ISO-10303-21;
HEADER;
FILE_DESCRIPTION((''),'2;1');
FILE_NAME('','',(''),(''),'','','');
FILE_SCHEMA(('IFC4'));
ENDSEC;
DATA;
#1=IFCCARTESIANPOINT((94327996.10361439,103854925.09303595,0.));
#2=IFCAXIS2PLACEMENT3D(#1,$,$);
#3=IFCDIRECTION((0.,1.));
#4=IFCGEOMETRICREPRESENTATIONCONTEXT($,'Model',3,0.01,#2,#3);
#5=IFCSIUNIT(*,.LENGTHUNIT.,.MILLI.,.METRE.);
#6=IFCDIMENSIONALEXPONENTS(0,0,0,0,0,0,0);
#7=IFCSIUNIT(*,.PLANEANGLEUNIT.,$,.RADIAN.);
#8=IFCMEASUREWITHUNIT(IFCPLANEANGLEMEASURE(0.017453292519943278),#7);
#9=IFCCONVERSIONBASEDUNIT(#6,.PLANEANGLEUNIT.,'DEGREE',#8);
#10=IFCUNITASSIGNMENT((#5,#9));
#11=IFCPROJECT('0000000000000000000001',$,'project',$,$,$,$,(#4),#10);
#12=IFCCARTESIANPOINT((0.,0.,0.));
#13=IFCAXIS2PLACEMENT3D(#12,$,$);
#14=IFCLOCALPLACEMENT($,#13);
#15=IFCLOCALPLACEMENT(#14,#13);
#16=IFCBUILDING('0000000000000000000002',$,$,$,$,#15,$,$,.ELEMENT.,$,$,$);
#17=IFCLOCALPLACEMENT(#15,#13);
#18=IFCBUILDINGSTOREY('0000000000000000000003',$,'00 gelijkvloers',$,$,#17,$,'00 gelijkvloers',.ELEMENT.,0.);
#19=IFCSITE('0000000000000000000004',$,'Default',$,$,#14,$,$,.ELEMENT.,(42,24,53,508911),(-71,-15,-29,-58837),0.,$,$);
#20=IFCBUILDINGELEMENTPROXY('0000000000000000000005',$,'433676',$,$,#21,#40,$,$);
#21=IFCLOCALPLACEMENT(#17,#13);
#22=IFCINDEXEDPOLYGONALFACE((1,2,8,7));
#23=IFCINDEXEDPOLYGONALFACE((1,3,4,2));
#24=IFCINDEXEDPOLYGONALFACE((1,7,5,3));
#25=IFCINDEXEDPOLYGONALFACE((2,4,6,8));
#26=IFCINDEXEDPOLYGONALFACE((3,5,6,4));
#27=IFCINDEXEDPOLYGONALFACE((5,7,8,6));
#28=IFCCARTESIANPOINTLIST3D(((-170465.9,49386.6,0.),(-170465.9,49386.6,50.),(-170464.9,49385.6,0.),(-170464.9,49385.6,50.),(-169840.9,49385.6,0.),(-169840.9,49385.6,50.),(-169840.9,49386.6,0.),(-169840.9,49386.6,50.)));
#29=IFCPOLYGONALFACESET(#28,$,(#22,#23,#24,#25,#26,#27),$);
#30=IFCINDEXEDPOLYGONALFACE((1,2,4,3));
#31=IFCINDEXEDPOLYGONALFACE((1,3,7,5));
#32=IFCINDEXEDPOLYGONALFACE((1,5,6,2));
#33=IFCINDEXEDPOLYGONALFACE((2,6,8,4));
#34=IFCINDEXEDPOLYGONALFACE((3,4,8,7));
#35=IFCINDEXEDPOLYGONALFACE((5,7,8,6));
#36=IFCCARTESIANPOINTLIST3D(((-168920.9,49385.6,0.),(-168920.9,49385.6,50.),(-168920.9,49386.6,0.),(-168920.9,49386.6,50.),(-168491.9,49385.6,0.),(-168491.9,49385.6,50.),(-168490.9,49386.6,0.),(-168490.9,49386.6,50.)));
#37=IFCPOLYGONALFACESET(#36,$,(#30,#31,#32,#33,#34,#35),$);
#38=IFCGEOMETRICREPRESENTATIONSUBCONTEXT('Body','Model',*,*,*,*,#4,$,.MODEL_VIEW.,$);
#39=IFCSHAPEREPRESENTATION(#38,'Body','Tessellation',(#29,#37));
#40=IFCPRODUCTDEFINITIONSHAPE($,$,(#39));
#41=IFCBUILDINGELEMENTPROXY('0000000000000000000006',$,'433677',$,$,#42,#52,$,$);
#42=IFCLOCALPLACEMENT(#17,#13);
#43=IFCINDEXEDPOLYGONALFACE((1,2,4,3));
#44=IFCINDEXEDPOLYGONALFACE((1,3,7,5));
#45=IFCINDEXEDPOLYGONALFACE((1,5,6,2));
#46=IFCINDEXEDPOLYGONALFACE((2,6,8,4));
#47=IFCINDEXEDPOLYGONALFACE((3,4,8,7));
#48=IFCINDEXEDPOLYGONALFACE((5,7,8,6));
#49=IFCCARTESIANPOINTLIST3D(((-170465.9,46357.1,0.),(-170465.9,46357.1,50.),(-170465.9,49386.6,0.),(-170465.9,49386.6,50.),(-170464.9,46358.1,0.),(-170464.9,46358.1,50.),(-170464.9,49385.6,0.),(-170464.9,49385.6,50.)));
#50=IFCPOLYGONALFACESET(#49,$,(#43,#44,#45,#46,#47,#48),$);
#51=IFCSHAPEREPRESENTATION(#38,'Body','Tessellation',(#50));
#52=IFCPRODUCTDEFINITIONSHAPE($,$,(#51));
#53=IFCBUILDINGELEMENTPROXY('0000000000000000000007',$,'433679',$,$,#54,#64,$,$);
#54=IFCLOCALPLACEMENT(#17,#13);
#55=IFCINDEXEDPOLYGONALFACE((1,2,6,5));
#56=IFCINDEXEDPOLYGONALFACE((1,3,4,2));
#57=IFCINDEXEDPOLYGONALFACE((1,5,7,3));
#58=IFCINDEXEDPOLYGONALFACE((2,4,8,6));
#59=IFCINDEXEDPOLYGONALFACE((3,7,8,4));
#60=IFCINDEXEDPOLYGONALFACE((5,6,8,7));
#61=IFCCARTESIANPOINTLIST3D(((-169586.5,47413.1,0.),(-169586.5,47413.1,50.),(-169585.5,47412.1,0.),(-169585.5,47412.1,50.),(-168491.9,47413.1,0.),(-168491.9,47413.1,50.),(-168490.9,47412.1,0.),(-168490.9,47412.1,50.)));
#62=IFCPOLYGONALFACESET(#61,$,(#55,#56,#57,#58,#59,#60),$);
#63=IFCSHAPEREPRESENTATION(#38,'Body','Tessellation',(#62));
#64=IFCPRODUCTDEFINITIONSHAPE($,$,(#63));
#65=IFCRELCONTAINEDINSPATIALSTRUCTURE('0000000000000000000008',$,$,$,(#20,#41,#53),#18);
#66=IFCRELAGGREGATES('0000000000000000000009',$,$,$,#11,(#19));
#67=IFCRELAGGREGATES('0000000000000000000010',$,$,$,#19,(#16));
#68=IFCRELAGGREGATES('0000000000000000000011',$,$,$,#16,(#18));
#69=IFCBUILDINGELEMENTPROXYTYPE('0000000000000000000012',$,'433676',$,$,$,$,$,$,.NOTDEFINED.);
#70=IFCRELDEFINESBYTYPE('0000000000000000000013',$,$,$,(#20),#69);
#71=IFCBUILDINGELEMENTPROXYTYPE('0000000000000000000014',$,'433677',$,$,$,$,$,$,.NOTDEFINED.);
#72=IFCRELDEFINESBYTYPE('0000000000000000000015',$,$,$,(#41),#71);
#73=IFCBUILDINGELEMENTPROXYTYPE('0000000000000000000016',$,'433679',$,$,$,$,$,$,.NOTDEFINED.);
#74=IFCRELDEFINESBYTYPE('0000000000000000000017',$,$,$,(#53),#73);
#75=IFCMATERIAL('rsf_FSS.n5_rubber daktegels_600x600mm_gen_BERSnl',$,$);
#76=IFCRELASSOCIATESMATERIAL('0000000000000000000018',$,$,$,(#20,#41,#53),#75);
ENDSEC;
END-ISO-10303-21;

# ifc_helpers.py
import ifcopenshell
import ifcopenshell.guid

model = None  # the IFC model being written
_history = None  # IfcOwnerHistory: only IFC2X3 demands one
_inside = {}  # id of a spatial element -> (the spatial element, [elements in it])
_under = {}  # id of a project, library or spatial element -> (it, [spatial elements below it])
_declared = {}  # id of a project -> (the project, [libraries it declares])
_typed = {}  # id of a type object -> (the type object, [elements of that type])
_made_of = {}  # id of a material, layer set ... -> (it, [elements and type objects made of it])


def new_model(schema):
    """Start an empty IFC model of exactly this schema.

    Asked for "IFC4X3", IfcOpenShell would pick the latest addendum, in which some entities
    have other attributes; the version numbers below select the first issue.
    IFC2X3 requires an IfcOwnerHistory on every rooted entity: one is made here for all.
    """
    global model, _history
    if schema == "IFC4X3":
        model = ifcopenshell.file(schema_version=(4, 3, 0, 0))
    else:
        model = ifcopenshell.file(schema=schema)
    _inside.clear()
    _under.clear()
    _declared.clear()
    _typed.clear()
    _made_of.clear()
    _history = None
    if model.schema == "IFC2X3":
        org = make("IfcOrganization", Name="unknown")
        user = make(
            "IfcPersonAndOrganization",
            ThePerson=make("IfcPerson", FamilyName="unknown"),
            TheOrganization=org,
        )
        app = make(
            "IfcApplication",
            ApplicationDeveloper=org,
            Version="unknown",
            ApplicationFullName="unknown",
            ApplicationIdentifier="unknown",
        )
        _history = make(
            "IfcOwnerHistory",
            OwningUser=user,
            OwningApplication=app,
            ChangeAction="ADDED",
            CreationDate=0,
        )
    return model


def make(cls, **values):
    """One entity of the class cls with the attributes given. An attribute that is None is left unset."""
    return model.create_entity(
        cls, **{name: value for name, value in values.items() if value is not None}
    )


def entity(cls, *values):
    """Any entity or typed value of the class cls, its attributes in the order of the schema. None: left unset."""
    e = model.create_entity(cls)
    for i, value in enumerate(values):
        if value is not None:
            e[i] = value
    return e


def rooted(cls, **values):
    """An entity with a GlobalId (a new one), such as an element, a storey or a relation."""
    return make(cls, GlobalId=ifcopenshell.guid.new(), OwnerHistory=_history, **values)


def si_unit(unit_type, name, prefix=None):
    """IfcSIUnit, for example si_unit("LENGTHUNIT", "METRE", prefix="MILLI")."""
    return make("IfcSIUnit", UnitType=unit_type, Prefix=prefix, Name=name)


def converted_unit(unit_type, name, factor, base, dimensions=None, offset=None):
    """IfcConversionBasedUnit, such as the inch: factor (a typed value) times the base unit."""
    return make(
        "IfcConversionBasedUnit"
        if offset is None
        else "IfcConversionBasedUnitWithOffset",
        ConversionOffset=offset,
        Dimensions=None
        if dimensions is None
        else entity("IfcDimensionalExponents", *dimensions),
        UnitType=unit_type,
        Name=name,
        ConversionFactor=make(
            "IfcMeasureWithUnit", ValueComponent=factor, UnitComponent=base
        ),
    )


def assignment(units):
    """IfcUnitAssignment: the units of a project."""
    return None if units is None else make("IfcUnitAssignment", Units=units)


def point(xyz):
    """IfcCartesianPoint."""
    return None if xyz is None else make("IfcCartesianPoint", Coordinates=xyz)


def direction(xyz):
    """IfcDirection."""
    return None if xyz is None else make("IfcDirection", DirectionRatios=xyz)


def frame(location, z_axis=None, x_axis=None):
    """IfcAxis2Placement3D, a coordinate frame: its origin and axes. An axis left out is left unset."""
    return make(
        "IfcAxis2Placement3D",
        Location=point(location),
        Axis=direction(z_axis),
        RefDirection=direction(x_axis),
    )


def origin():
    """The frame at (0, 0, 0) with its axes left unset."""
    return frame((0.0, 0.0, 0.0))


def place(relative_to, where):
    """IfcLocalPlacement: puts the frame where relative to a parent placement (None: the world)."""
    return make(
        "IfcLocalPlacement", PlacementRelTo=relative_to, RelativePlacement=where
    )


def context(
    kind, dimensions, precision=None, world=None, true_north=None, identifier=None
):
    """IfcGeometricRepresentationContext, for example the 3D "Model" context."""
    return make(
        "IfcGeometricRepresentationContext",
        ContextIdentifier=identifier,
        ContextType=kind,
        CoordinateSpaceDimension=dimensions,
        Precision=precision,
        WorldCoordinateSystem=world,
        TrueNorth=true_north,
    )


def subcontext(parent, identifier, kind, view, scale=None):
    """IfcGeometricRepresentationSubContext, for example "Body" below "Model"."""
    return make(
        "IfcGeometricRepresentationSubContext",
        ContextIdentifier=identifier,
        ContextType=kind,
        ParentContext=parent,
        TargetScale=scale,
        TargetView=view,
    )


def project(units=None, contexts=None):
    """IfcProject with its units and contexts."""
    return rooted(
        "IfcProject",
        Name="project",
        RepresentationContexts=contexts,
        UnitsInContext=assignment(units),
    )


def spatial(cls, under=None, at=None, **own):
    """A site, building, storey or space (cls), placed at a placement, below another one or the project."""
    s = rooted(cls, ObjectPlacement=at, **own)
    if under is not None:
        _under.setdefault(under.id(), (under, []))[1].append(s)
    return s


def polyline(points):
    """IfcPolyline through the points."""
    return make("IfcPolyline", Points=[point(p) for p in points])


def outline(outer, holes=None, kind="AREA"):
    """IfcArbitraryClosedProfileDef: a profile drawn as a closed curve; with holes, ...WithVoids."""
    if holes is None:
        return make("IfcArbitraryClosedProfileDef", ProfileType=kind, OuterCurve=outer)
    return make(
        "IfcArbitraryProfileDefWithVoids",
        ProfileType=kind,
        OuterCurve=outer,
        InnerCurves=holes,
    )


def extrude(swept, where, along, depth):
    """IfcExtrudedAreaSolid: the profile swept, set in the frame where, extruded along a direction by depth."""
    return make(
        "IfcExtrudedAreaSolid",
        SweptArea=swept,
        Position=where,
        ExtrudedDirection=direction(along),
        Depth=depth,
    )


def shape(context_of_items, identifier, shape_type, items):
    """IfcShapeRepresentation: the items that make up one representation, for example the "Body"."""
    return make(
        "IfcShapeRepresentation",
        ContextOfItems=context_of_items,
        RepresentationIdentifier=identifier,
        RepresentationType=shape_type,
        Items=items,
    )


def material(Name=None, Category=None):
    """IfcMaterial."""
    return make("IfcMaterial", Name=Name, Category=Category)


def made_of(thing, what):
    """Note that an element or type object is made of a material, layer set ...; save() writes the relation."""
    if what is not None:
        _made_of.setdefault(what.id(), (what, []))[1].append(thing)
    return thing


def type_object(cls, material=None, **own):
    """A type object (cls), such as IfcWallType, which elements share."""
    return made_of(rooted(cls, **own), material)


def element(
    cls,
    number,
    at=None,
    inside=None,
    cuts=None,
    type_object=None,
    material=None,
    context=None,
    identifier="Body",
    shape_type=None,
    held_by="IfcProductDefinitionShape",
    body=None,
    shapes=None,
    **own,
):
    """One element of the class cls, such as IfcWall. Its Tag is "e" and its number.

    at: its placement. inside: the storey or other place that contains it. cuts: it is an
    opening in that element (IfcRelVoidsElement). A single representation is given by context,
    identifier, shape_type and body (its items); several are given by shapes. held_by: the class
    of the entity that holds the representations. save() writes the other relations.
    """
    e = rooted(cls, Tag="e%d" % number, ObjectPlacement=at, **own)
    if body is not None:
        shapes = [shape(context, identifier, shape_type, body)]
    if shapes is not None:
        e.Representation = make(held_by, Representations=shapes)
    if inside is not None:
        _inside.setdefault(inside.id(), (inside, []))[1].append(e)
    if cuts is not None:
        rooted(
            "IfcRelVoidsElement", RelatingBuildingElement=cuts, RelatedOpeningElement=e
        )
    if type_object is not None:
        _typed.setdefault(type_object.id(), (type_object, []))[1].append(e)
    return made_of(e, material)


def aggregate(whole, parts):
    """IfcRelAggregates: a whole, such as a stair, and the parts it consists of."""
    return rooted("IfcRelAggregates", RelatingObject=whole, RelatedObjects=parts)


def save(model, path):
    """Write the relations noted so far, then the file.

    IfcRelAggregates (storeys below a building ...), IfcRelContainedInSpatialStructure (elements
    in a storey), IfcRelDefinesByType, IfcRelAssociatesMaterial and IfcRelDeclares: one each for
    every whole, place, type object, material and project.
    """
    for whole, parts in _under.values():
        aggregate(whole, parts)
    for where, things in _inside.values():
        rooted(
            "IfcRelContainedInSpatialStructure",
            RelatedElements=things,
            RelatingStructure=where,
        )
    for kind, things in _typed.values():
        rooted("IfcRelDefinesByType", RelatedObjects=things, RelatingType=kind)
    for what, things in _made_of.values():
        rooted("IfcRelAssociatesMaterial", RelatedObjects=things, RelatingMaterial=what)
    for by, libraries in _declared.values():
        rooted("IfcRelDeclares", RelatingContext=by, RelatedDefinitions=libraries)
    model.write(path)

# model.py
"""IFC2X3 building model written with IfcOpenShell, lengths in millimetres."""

from ifc_helpers import new_model, entity, si_unit, converted_unit, direction, frame, origin, place, context, subcontext, project, spatial, polyline, outline, extrude, material, type_object, element, save


model = new_model("IFC2X3")

# Units and contexts
model_context = context("Model", 3, precision=0.01, world=frame((94327996.10361439, 103854925.09303595, 0.0)), true_north=direction((0.0, 1.0)))
body_context = subcontext(model_context, "Body", "Model", "MODEL_VIEW")
ifc_project = project(units=[si_unit("LENGTHUNIT", "METRE", prefix="MILLI"), converted_unit("PLANEANGLEUNIT", "DEGREE", entity("IfcPlaneAngleMeasure", 0.017453292519943278), si_unit("PLANEANGLEUNIT", "RADIAN"), dimensions=[0, 0, 0, 0, 0, 0, 0])], contexts=[model_context])

# Site, building, storey
site_placement = place(None, origin())
site = spatial("IfcSite", under=ifc_project, at=site_placement, Name="Default", CompositionType="ELEMENT", RefLatitude=(42, 24, 53, 508911), RefLongitude=(-71, -15, -29, -58837), RefElevation=0.0)
building_placement = place(site_placement, origin())
building = spatial("IfcBuilding", under=site, at=building_placement, CompositionType="ELEMENT")
storey_placement = place(building_placement, origin())
storey = spatial("IfcBuildingStorey", under=building, at=storey_placement, Name="00 gelijkvloers", LongName="00 gelijkvloers", CompositionType="ELEMENT", Elevation=0.0)

# Building element proxies
ifc_material = material(Name="rsf_FSS.n5_rubber daktegels_600x600mm_gen_BERSnl")
building_element_proxy_type_1 = type_object("IfcBuildingElementProxyType", Name="433676", PredefinedType="NOTDEFINED")
proxy_1_placement = place(storey_placement, origin())
element("IfcBuildingElementProxy", 1, at=proxy_1_placement, inside=storey, type_object=building_element_proxy_type_1, material=ifc_material, Name="433676", context=body_context, shape_type="SweptSolid", body=[
    extrude(outline(polyline([(-311.7, -0.5), (312.2, -0.5), (312.2, 0.5), (-312.7, 0.5), (-311.7, -0.5)])), frame((-170153.1, 49386.1, 0.0)), (0.0, 0.0, 1.0), 50.0),
    extrude(outline(polyline([(-214.8, -0.5), (214.3, -0.5), (215.3, 0.5), (-214.8, 0.5), (-214.8, -0.5)])), frame((-168706.1, 49386.1, 0.0)), (0.0, 0.0, 1.0), 50.0),
])
building_element_proxy_type_2 = type_object("IfcBuildingElementProxyType", Name="433677", PredefinedType="NOTDEFINED")
proxy_2_placement = place(storey_placement, origin())
element("IfcBuildingElementProxy", 2, at=proxy_2_placement, inside=storey, type_object=building_element_proxy_type_2, material=ifc_material, Name="433677", context=body_context, shape_type="SweptSolid", body=[
    extrude(outline(polyline([(-1513.8, -0.5), (1513.8, -0.5), (1514.8, 0.5), (-1514.8, 0.5), (-1513.8, -0.5)])), frame((-170465.4, 47871.8, 0.0), z_axis=(0.0, 0.0, 1.0), x_axis=(0.0, 1.0, 0.0)), (0.0, 0.0, 1.0), 50.0),
])
building_element_proxy_type_3 = type_object("IfcBuildingElementProxyType", Name="433679", PredefinedType="NOTDEFINED")
proxy_3_placement = place(storey_placement, origin())
element("IfcBuildingElementProxy", 3, at=proxy_3_placement, inside=storey, type_object=building_element_proxy_type_3, material=ifc_material, Name="433679", context=body_context, shape_type="SweptSolid", body=[
    extrude(outline(polyline([(-546.8, -0.5), (547.8, -0.5), (546.8, 0.5), (-547.8, 0.5), (-546.8, -0.5)])), frame((-169038.7, 47412.6, 0.0), z_axis=(0.0, 0.0, 1.0), x_axis=(-1.0, 0.0, 0.0)), (0.0, 0.0, 1.0), 50.0),
])

save(model, "model.ifc")
